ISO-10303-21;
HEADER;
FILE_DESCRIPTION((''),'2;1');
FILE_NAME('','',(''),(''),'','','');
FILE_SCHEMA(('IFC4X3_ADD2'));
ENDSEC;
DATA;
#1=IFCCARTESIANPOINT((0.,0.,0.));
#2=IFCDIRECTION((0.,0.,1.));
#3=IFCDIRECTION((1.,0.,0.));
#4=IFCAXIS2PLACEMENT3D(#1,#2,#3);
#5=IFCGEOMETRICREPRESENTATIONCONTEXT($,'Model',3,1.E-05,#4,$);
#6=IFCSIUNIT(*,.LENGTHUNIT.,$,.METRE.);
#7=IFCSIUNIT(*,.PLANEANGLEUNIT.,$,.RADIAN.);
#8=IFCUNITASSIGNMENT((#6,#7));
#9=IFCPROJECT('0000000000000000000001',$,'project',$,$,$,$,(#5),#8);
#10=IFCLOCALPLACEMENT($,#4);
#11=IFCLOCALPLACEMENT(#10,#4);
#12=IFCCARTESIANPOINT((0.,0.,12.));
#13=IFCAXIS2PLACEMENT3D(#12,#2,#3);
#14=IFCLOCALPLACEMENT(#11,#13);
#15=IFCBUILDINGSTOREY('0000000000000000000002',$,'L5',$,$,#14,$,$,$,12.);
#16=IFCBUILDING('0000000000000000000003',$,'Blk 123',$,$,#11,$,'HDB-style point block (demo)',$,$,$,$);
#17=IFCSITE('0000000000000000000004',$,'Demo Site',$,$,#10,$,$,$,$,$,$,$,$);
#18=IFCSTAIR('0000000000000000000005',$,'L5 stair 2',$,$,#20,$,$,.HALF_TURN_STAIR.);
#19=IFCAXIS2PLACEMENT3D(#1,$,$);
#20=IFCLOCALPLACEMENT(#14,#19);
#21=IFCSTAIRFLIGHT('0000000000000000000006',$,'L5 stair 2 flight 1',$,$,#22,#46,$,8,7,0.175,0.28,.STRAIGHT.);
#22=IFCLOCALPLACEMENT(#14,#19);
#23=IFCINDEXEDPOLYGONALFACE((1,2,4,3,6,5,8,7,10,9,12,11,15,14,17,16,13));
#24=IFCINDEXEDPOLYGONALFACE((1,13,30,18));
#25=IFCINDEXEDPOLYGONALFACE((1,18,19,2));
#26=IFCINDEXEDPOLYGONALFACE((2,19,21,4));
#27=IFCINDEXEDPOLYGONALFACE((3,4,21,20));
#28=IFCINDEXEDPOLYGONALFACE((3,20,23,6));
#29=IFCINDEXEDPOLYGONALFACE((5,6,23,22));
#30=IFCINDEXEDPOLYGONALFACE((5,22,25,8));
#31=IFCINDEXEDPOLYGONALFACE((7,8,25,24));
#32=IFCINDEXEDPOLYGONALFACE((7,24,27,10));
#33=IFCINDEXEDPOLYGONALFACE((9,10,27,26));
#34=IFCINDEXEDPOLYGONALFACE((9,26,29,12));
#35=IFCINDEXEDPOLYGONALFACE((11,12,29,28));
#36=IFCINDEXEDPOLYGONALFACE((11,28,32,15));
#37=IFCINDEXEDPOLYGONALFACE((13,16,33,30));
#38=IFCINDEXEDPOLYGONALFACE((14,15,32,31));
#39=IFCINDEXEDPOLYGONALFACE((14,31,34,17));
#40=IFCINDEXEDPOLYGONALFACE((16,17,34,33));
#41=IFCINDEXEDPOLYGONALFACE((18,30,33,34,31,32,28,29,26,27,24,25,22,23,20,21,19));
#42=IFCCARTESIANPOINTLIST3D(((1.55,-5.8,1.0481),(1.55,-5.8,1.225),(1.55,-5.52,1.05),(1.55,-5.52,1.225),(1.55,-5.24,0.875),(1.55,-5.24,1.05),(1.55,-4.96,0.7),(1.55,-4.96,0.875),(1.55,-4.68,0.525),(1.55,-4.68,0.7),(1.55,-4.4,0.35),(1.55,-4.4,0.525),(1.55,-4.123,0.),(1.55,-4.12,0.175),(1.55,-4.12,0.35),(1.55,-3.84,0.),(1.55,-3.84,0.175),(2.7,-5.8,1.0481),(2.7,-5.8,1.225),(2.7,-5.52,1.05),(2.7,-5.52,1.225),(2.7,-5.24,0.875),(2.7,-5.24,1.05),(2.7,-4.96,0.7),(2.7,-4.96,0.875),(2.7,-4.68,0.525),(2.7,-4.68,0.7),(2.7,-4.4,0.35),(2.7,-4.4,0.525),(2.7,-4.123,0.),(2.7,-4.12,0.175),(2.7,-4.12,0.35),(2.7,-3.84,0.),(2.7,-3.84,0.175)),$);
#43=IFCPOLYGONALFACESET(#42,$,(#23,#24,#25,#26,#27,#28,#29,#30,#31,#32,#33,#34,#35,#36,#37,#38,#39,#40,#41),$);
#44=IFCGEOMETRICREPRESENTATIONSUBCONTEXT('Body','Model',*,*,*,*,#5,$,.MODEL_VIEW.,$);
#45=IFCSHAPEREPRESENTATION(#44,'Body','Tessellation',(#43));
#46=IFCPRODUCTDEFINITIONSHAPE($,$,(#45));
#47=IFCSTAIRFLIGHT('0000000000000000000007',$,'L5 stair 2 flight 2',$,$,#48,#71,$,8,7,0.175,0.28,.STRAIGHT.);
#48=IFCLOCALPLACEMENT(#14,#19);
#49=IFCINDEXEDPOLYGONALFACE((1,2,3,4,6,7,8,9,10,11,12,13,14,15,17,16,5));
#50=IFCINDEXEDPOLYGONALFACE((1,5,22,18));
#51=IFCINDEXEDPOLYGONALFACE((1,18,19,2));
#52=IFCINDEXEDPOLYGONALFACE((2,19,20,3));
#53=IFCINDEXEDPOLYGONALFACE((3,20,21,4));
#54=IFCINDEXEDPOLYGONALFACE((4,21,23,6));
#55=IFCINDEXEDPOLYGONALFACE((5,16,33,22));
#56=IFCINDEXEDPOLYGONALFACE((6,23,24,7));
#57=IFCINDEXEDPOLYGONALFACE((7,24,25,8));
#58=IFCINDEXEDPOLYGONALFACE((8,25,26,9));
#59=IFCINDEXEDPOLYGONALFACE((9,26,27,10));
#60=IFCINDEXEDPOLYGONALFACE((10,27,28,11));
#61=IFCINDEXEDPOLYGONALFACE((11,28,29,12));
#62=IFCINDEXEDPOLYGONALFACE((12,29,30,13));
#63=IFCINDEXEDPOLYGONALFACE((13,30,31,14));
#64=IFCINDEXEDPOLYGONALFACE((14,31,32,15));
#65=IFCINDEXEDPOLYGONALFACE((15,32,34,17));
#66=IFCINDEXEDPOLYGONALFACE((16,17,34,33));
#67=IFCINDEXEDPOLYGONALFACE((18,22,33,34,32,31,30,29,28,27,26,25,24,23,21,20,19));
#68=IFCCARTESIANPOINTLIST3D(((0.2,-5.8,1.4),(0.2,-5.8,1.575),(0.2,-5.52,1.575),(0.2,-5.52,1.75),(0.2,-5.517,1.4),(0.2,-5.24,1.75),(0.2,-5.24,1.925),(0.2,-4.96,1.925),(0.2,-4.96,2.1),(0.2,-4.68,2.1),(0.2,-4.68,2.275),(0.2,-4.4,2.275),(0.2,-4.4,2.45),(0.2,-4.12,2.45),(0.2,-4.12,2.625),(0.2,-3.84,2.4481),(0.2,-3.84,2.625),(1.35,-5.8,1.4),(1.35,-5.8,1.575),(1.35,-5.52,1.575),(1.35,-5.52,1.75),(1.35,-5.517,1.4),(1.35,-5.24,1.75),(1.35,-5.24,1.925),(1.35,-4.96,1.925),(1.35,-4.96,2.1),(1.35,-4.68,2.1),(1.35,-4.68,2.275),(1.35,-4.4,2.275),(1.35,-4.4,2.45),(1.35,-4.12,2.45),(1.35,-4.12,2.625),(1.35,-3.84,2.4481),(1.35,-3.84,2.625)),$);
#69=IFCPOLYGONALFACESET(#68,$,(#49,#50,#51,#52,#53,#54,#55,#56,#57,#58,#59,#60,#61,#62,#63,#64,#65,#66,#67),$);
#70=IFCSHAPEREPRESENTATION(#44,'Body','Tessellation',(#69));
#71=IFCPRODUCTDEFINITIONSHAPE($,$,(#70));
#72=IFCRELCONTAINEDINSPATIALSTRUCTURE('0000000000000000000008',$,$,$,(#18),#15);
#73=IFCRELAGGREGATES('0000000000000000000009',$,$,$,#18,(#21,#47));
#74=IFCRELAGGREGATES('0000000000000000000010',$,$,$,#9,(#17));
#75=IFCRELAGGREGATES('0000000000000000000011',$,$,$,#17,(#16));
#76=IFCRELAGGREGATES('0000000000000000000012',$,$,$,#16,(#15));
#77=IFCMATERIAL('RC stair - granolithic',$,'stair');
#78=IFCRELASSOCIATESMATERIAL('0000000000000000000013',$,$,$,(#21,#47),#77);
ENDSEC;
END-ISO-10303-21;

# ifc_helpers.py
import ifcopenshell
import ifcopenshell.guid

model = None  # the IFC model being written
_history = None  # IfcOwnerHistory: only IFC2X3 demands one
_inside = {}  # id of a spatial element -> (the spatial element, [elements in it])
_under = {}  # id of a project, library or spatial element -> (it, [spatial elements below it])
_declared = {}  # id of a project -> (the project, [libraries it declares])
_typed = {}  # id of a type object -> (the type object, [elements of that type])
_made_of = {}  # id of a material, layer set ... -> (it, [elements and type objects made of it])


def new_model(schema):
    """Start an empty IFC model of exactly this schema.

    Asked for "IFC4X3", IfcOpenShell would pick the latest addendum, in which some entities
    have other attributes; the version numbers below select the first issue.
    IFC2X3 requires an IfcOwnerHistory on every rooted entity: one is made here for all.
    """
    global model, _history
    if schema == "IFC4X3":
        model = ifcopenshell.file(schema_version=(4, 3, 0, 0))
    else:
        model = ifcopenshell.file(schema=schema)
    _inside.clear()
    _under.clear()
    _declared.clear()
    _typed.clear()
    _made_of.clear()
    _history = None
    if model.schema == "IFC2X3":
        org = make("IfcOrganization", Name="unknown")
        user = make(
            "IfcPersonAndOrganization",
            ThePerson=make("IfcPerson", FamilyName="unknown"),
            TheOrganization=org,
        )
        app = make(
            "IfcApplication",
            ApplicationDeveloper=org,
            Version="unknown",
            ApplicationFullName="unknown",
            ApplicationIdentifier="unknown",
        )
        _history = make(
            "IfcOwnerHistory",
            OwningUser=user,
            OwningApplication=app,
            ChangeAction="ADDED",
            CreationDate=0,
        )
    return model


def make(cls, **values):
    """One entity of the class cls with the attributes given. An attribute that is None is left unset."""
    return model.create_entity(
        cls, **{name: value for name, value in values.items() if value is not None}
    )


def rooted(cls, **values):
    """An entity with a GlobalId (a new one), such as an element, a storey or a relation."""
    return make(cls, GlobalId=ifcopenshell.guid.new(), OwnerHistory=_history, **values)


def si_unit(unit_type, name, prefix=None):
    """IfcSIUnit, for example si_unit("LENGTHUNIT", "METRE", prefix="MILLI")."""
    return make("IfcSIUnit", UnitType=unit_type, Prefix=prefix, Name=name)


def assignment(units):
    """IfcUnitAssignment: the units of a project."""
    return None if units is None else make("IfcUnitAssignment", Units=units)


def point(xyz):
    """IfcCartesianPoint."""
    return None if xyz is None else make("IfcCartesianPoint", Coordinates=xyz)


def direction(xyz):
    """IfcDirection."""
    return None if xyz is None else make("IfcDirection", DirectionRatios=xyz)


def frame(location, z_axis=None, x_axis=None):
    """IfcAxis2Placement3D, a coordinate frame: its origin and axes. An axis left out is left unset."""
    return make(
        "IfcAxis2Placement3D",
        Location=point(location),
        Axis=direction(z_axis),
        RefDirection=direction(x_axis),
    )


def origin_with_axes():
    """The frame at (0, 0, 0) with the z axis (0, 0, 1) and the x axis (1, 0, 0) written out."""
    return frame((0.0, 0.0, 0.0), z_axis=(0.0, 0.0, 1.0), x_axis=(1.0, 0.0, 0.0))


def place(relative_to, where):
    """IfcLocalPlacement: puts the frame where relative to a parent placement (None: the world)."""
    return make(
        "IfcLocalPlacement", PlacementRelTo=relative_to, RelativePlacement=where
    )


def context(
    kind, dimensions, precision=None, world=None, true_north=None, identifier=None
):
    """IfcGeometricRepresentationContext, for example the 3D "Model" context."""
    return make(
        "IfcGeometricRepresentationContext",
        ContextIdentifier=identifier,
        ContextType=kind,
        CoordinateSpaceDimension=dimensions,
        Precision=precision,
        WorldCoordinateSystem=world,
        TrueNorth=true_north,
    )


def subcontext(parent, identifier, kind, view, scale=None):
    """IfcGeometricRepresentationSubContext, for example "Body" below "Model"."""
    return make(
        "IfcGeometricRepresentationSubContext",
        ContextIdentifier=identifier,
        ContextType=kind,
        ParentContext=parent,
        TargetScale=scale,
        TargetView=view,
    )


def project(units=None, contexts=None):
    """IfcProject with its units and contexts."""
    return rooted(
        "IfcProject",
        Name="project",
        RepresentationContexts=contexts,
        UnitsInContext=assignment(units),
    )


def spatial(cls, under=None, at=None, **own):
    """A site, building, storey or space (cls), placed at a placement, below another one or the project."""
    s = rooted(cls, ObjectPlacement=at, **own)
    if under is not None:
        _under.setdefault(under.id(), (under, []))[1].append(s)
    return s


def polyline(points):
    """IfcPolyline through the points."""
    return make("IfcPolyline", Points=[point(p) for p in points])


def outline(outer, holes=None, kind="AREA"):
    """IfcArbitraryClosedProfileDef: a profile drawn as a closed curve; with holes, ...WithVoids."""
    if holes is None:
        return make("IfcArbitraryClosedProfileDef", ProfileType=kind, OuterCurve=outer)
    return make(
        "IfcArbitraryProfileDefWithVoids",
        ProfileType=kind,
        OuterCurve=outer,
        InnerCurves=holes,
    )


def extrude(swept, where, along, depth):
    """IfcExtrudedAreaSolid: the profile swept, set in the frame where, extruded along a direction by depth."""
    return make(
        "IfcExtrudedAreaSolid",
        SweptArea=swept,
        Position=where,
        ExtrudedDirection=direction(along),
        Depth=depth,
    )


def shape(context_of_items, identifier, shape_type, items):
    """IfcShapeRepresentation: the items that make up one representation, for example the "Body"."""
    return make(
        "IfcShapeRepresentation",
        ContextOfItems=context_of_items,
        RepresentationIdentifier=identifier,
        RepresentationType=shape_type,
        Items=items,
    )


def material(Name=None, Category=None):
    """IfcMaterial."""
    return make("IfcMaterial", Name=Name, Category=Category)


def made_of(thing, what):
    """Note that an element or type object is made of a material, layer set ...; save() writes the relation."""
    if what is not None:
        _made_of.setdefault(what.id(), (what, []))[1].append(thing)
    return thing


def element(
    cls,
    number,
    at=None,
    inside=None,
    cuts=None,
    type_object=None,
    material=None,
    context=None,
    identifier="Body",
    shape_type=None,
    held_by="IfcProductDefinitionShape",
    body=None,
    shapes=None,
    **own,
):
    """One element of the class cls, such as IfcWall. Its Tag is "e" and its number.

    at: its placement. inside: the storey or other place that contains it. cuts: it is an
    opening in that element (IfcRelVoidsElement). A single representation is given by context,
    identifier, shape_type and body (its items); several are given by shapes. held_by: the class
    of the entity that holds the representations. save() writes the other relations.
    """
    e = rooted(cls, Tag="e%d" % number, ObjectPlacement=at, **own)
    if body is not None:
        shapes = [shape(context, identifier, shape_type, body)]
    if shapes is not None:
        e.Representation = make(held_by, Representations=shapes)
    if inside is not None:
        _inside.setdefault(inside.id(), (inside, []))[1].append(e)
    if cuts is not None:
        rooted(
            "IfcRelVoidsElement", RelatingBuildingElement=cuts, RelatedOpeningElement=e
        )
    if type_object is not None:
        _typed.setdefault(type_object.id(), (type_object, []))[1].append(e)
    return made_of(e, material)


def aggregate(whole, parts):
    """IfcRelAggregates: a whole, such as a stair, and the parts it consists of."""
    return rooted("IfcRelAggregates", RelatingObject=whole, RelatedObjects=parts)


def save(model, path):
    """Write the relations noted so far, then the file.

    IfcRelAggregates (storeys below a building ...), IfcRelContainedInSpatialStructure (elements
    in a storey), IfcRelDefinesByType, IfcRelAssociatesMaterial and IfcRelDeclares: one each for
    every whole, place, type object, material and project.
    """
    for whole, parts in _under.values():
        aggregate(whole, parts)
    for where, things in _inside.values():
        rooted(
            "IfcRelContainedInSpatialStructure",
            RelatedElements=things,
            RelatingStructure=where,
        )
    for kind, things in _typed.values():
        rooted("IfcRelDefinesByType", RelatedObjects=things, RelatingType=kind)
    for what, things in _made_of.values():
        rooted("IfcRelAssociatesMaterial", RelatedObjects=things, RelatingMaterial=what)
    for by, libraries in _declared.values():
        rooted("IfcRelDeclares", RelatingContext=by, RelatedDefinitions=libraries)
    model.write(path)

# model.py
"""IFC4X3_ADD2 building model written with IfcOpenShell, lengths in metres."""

from ifc_helpers import new_model, si_unit, frame, origin_with_axes, place, context, subcontext, project, spatial, polyline, outline, extrude, material, element, aggregate, save


model = new_model("IFC4X3_ADD2")

# Units and contexts
model_context = context("Model", 3, precision=1e-05, world=origin_with_axes())
body_context = subcontext(model_context, "Body", "Model", "MODEL_VIEW")
ifc_project = project(units=[si_unit("LENGTHUNIT", "METRE"), si_unit("PLANEANGLEUNIT", "RADIAN")], contexts=[model_context])

# Site, building, storey
site_placement = place(None, origin_with_axes())
site = spatial("IfcSite", under=ifc_project, at=site_placement, Name="Demo Site")
building_placement = place(site_placement, origin_with_axes())
building = spatial("IfcBuilding", under=site, at=building_placement, Name="Blk 123", LongName="HDB-style point block (demo)")
storey_placement = place(building_placement, frame((0.0, 0.0, 12.0), z_axis=(0.0, 0.0, 1.0), x_axis=(1.0, 0.0, 0.0)))
storey = spatial("IfcBuildingStorey", under=building, at=storey_placement, Name="L5", Elevation=12.0)

# Stair
stair_placement = place(storey_placement, frame((0.2, -7.1, 0.0), z_axis=(0.0, 0.0, 1.0), x_axis=(1.0, 0.0, 0.0)))
stair = element("IfcStair", 1, at=stair_placement, inside=storey, Name="L5 stair 2", PredefinedType="HALF_TURN_STAIR")
ifc_material_1 = material(Name="RC stair - granolithic", Category="stair")

# Stair flights
stair_flight_1_placement = place(stair_placement, frame((2.5, 3.26, 0.0), z_axis=(0.0, 0.0, 1.0), x_axis=(1.0, 0.0, 0.0)))
stair_flight_1 = element("IfcStairFlight", 2, at=stair_flight_1_placement, material=ifc_material_1, Name="L5 stair 2 flight 1", NumberOfRisers=8, NumberOfTreads=7, PredefinedType="STRAIGHT", RiserHeight=0.175, TreadLength=0.28, context=body_context, shape_type="SweptSolid", body=[
    extrude(outline(polyline([(0.0, 0.0), (0.0, 0.175), (0.28, 0.175), (0.28, 0.35), (0.56, 0.35), (0.56, 0.525), (0.84, 0.525), (0.84, 0.7), (1.12, 0.7), (1.12, 0.875), (1.4, 0.875), (1.4, 1.05), (1.68, 1.05), (1.68, 1.225), (1.96, 1.225), (1.96, 1.4), (1.96, 1.0481), (0.283, 0.0), (0.0, 0.0)])), frame((0.0, 0.0, 0.0), z_axis=(-1.0, 0.0, 0.0), x_axis=(0.0, -1.0, 0.0)), (0.0, 0.0, 1.0), 1.15),
])
stair_flight_2_placement = place(stair_placement, frame((0.0, 1.3, 1.4), z_axis=(0.0, 0.0, 1.0), x_axis=(1.0, 0.0, 0.0)))
stair_flight_2 = element("IfcStairFlight", 3, at=stair_flight_2_placement, material=ifc_material_1, Name="L5 stair 2 flight 2", NumberOfRisers=8, NumberOfTreads=7, PredefinedType="STRAIGHT", RiserHeight=0.175, TreadLength=0.28, context=body_context, shape_type="SweptSolid", body=[
    extrude(outline(polyline([(0.0, 0.0), (0.0, 0.175), (0.28, 0.175), (0.28, 0.35), (0.56, 0.35), (0.56, 0.525), (0.84, 0.525), (0.84, 0.7), (1.12, 0.7), (1.12, 0.875), (1.4, 0.875), (1.4, 1.05), (1.68, 1.05), (1.68, 1.225), (1.96, 1.225), (1.96, 1.4), (1.96, 1.0481), (0.283, 0.0), (0.0, 0.0)])), frame((0.0, 0.0, 0.0), z_axis=(1.0, 0.0, 0.0), x_axis=(0.0, 1.0, 0.0)), (0.0, 0.0, 1.0), 1.15),
])

aggregate(stair, [stair_flight_1, stair_flight_2])

save(model, "model.ifc")
